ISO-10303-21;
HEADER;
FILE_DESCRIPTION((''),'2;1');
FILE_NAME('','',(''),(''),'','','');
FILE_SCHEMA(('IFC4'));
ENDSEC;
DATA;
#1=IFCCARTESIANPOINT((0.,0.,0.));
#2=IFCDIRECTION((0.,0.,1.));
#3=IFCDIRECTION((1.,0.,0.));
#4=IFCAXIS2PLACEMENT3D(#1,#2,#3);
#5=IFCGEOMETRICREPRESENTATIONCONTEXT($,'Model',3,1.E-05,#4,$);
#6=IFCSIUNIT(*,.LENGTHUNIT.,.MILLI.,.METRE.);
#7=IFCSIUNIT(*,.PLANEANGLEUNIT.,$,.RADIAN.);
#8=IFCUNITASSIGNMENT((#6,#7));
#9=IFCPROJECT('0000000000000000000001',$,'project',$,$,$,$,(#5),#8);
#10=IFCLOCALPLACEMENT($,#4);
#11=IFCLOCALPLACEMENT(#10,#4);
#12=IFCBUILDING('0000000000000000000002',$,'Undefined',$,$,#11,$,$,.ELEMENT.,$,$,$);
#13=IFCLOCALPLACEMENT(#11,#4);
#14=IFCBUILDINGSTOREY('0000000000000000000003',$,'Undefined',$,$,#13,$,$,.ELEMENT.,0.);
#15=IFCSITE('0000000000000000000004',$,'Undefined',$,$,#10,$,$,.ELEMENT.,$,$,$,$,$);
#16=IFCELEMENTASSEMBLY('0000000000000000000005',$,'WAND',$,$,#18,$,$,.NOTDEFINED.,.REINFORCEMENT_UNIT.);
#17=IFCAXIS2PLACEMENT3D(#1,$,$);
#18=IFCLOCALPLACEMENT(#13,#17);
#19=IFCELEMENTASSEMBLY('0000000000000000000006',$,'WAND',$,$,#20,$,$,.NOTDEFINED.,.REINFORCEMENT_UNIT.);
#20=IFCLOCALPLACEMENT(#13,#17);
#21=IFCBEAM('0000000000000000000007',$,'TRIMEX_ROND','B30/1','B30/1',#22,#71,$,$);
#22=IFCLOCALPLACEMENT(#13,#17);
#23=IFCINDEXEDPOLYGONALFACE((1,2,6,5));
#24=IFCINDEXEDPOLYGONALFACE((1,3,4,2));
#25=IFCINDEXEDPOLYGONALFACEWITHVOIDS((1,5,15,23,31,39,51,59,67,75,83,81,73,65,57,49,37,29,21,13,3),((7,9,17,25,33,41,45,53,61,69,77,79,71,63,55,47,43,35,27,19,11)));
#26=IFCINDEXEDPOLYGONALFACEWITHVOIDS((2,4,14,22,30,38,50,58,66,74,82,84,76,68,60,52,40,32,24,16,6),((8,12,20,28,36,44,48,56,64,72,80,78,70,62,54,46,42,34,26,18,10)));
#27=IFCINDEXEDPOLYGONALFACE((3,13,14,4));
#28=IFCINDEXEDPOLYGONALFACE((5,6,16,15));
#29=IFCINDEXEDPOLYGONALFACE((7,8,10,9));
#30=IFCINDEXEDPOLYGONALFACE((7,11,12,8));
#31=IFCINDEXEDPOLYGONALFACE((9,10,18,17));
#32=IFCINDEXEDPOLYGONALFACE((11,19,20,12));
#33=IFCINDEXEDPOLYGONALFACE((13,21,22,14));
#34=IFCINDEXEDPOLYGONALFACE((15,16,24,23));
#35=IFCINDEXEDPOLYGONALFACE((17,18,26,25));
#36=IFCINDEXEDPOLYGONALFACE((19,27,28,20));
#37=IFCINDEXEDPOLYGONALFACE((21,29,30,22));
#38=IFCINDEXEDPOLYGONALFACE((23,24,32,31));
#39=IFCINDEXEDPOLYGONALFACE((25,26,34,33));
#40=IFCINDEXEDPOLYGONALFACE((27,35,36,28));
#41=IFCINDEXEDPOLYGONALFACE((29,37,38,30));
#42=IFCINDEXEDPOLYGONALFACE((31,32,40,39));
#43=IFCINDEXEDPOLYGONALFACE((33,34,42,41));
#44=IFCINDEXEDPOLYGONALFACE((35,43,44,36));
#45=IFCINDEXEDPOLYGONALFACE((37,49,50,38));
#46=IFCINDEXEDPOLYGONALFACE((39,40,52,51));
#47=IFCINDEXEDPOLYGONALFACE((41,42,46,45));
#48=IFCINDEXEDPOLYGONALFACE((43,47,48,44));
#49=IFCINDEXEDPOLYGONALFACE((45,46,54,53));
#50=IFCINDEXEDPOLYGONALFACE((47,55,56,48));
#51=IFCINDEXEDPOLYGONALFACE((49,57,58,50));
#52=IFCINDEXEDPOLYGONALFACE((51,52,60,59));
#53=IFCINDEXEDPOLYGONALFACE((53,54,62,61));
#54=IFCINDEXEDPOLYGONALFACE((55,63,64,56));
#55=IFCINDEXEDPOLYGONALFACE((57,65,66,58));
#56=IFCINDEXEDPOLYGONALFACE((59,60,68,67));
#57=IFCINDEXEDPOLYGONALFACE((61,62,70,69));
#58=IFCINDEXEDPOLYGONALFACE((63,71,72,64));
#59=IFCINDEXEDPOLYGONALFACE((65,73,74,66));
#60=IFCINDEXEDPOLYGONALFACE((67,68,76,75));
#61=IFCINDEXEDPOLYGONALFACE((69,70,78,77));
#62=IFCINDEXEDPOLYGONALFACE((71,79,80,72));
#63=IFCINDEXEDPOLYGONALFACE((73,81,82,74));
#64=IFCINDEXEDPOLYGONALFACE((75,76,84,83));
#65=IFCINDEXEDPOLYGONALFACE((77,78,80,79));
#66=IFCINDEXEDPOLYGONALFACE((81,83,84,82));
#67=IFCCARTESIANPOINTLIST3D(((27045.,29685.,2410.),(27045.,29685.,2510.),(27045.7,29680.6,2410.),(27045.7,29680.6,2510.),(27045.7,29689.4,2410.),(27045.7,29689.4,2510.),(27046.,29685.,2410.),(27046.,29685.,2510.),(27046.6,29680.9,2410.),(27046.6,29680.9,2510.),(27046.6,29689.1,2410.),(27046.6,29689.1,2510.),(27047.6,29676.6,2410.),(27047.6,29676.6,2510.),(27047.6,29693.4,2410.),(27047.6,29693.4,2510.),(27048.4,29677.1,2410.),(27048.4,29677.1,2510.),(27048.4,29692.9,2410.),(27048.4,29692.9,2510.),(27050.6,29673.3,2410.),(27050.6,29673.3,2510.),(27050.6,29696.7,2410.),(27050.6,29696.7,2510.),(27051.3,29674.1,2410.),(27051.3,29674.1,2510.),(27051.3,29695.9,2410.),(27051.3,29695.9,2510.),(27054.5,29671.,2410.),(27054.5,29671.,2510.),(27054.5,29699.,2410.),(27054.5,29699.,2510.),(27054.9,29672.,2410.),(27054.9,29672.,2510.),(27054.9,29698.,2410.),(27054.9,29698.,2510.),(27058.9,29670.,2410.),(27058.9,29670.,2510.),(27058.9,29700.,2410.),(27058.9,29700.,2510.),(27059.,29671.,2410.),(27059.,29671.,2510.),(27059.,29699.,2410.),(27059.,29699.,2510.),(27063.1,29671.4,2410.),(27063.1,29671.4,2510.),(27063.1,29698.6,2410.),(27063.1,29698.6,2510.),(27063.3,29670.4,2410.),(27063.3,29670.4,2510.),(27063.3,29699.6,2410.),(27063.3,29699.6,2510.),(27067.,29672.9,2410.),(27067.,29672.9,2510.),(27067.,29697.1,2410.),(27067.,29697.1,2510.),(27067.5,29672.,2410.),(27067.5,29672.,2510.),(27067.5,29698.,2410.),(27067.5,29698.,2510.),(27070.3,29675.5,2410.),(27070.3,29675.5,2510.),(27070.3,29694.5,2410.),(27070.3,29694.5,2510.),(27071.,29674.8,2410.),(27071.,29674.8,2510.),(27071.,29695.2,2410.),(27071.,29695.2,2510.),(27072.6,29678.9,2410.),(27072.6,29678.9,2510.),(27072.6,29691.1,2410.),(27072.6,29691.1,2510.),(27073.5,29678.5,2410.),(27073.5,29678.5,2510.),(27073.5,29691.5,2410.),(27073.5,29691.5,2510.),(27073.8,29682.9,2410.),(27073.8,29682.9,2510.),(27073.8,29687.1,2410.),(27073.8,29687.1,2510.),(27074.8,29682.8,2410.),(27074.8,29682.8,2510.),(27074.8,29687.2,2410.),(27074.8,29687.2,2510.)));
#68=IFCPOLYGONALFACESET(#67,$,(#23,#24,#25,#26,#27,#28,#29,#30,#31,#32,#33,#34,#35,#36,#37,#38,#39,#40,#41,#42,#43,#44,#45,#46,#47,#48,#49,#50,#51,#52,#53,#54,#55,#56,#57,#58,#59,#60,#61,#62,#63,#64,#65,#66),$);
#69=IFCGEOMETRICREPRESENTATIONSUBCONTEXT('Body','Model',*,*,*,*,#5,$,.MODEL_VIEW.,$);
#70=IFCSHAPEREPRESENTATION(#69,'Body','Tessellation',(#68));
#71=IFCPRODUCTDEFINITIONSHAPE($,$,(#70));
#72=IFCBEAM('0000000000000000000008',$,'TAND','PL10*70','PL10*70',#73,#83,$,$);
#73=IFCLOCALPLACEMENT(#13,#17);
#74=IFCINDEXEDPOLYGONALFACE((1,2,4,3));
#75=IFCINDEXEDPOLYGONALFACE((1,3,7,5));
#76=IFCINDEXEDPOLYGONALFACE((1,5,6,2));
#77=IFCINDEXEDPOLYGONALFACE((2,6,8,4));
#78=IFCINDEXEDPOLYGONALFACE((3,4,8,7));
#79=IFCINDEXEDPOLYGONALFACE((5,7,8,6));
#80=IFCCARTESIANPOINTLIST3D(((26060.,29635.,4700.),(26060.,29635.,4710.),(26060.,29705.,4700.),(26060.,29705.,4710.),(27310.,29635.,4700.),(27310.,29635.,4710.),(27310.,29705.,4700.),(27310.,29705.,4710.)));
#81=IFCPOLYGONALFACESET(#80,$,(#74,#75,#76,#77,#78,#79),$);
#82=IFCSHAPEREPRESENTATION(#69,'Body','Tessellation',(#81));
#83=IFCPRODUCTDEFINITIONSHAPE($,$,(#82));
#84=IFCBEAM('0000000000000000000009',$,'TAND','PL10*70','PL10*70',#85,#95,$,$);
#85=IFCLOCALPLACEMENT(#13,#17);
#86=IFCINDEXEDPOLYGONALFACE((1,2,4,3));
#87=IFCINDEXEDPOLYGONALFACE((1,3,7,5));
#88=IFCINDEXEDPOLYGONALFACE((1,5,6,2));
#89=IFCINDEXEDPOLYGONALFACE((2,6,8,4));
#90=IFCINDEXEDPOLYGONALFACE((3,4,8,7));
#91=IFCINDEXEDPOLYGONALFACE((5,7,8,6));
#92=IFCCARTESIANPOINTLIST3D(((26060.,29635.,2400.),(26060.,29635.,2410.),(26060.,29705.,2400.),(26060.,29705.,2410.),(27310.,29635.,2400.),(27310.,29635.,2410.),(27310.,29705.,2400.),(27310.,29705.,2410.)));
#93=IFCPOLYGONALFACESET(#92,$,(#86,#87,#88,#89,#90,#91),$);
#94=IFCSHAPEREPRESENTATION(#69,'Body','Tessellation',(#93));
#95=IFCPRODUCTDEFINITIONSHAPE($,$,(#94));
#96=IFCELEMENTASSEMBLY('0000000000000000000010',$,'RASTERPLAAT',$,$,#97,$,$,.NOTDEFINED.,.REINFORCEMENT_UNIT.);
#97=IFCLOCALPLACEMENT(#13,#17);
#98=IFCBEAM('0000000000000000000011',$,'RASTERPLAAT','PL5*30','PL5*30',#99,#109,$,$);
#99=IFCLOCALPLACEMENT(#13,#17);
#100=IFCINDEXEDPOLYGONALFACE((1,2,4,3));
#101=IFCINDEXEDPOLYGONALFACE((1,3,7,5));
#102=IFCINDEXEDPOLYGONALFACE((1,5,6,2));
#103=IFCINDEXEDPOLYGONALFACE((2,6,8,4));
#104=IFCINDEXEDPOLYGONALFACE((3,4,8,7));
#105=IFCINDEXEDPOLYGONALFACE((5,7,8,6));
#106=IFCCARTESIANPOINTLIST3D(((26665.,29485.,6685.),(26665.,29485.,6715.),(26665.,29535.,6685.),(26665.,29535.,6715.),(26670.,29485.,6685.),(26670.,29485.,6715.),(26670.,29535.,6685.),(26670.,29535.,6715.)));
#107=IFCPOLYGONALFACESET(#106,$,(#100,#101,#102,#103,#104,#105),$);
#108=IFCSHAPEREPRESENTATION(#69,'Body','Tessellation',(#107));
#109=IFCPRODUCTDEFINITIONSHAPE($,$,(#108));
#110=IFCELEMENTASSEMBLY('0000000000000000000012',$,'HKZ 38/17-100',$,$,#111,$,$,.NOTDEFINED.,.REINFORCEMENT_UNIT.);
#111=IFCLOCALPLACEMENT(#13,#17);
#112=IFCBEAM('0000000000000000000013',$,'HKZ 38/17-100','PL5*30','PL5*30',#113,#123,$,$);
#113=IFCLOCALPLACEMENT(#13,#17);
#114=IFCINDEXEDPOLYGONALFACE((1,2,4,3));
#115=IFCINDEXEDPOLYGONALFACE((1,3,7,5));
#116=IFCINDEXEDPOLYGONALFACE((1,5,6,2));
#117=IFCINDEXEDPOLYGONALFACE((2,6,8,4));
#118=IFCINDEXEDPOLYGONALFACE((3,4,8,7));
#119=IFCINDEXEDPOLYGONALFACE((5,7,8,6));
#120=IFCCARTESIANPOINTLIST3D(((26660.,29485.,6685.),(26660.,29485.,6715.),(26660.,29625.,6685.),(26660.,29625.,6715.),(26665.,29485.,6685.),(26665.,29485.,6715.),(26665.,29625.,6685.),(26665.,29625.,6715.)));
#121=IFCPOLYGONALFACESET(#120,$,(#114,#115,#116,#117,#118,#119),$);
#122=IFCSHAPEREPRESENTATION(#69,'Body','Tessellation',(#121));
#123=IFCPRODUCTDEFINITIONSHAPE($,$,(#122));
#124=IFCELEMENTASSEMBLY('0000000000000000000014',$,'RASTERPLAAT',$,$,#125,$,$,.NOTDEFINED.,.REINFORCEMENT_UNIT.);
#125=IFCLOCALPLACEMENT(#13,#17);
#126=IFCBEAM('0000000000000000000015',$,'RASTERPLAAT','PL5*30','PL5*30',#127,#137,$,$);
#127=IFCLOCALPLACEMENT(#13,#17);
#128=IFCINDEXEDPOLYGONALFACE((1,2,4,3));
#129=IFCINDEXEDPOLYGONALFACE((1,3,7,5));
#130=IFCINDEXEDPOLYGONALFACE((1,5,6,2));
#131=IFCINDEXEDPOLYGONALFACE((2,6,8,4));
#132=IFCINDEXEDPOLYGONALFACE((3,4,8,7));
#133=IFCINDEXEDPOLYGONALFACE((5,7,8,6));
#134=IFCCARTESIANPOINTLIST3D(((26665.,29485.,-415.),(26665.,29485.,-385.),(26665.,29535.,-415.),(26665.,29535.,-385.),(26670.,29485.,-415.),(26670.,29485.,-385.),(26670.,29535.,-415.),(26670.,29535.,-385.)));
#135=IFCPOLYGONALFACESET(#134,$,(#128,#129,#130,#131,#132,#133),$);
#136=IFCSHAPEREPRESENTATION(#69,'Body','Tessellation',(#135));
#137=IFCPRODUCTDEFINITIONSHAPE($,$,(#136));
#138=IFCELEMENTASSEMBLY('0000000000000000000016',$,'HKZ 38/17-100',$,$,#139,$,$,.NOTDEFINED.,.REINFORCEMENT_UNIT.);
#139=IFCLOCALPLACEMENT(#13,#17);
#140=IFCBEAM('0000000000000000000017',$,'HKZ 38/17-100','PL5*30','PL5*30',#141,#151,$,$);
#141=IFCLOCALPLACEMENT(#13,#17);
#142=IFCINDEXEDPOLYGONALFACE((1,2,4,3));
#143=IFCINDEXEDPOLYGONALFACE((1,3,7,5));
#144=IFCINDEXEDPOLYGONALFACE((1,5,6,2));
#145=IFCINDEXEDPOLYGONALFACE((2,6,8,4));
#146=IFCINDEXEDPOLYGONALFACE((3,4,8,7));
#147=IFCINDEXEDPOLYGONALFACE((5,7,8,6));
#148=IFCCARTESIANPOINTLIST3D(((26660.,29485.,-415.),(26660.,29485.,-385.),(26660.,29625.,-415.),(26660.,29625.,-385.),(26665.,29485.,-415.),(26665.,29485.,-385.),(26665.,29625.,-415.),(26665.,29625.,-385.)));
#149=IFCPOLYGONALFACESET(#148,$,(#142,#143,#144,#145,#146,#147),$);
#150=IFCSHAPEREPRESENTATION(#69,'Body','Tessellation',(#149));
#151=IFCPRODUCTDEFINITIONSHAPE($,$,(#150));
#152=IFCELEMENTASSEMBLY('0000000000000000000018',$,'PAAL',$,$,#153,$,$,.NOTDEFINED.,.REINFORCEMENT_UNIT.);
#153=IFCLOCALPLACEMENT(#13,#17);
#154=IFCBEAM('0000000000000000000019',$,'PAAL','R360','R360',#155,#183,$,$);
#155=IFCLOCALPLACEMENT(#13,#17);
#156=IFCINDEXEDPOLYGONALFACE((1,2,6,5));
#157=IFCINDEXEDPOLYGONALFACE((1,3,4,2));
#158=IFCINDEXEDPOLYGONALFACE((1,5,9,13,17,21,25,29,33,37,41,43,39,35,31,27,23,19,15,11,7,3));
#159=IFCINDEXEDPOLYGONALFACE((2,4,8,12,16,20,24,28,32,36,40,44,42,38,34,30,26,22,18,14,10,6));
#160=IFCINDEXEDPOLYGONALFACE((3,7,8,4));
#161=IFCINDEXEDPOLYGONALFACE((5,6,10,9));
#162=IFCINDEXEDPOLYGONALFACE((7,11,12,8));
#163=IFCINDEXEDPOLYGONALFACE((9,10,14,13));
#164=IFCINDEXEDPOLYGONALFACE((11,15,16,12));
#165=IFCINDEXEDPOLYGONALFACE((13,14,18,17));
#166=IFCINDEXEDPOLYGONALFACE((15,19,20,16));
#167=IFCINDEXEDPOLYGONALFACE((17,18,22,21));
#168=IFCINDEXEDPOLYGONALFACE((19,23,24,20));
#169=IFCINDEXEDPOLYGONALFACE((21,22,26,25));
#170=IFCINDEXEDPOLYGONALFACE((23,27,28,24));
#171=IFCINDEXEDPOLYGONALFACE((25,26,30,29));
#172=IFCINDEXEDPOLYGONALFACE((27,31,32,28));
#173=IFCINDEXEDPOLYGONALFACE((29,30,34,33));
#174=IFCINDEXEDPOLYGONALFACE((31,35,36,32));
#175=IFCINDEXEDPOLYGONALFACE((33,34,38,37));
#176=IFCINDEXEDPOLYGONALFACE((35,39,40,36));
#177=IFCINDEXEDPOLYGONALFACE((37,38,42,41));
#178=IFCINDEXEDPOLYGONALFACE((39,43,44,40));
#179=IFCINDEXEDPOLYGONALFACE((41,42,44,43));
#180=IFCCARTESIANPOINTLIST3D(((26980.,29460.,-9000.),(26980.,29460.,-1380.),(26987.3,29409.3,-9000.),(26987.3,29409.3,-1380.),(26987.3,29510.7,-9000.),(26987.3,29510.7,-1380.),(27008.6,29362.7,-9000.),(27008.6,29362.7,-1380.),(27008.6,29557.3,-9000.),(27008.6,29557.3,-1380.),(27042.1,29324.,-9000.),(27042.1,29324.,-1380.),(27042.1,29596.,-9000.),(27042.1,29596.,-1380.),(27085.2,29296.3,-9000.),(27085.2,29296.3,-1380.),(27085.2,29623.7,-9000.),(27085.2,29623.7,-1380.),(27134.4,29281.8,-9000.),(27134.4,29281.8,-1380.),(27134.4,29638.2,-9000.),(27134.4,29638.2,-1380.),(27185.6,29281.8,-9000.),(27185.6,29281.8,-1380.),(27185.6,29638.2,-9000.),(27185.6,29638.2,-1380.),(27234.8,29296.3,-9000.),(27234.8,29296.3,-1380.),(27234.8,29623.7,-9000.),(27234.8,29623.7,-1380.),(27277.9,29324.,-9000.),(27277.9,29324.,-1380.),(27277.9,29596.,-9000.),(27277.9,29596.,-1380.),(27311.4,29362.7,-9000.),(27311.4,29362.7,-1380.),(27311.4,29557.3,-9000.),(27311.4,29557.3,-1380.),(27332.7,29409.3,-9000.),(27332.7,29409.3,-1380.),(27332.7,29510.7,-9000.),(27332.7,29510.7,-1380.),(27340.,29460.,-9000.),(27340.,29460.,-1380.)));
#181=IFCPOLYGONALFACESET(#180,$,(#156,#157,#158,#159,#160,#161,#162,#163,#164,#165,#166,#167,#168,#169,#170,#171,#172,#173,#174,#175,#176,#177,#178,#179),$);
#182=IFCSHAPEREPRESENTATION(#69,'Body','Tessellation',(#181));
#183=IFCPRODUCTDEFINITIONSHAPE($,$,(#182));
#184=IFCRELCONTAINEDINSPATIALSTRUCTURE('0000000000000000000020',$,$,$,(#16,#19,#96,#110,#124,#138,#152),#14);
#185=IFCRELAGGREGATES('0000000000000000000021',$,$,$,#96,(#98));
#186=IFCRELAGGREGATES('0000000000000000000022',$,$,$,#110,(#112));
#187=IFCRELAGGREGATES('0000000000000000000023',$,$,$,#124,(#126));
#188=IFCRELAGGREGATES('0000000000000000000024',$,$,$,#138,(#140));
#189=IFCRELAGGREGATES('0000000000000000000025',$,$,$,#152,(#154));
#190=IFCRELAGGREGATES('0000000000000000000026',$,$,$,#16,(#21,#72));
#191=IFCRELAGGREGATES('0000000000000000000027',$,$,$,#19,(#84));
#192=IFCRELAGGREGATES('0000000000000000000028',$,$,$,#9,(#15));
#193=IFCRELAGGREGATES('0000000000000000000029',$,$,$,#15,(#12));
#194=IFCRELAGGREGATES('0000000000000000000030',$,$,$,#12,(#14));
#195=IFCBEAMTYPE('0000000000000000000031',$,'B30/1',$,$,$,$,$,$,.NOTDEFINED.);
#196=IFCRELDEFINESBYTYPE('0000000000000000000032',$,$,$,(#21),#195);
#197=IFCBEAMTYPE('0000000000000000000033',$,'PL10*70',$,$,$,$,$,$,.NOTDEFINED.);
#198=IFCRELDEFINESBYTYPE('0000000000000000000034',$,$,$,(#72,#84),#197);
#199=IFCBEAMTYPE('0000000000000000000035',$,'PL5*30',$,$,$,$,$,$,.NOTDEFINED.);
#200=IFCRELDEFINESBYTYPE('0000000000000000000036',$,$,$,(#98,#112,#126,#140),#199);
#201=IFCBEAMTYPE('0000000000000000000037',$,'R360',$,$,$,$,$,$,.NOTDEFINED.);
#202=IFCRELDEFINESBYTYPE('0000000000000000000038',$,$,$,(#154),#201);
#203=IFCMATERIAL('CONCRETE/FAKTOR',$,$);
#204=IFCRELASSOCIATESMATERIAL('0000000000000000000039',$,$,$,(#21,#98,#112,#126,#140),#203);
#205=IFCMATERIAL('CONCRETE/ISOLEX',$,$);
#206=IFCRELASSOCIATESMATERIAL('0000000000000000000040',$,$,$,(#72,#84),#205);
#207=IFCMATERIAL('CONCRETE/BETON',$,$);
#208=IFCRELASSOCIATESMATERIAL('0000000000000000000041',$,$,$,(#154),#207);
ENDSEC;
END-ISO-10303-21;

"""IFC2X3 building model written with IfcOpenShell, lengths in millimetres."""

from ifc_helpers import new_model, si_unit, frame, frame_2d, origin_with_axes, place, context, subcontext, project, spatial, rectangle, circle, hollow_circle, extrude, material, type_object, element, aggregate, save


model = new_model("IFC2X3")

# Units and contexts
model_context = context("Model", 3, precision=1e-05, world=origin_with_axes())
body_context = subcontext(model_context, "Body", "Model", "MODEL_VIEW")
ifc_project = project(units=[si_unit("LENGTHUNIT", "METRE", prefix="MILLI"), si_unit("PLANEANGLEUNIT", "RADIAN")], contexts=[model_context])

# Site, building, storey
site_placement = place(None, origin_with_axes())
site = spatial("IfcSite", under=ifc_project, at=site_placement, Name="Undefined", CompositionType="ELEMENT")
building_placement = place(site_placement, origin_with_axes())
building = spatial("IfcBuilding", under=site, at=building_placement, Name="Undefined", CompositionType="ELEMENT")
storey_placement = place(building_placement, origin_with_axes())
storey = spatial("IfcBuildingStorey", under=building, at=storey_placement, Name="Undefined", CompositionType="ELEMENT", Elevation=0.0)

# Element assemblies
assembly_1_placement = place(storey_placement, origin_with_axes())
assembly_1 = element("IfcElementAssembly", 1, at=assembly_1_placement, inside=storey, Name="WAND", AssemblyPlace="NOTDEFINED", PredefinedType="REINFORCEMENT_UNIT")
ifc_material_1 = material(Name="CONCRETE/BETON")
assembly_2_placement = place(storey_placement, origin_with_axes())
assembly_2 = element("IfcElementAssembly", 2, at=assembly_2_placement, inside=storey, Name="WAND", AssemblyPlace="NOTDEFINED", PredefinedType="REINFORCEMENT_UNIT")
ifc_material_2 = material(Name="CONCRETE/FAKTOR")

# Shared definitions
beam_type_1 = type_object("IfcBeamType", Name="B30/1", PredefinedType="NOTDEFINED")

# Beams
beam_1_placement = place(assembly_1_placement, frame((27060.0, 29685.0, 2410.0), z_axis=(0.0, 1.0, 0.0), x_axis=(0.0, 0.0, 1.0)))
beam_1 = element("IfcBeam", 3, at=beam_1_placement, type_object=beam_type_1, material=ifc_material_2, Name="TRIMEX_ROND", Description="B30/1", ObjectType="B30/1", context=body_context, shape_type="SweptSolid", body=[
    extrude(hollow_circle(Radius=15.0, WallThickness=1.0, at=frame_2d((0.0, 0.0), x_axis=(1.0, 0.0))), frame((100.0, 0.0, 0.0), z_axis=(-1.0, 0.0, 0.0), x_axis=(0.0, -1.0, 0.0)), (0.0, 0.0, 1.0), 100.0),
])
ifc_material_3 = material(Name="CONCRETE/ISOLEX")
beam_type_2 = type_object("IfcBeamType", Name="PL10*70", PredefinedType="NOTDEFINED")
beam_2_placement = place(assembly_1_placement, frame((27310.0, 29670.0, 4705.0), z_axis=(0.0, 1.0, 0.0), x_axis=(-1.0, 0.0, 0.0)))
beam_2 = element("IfcBeam", 4, at=beam_2_placement, type_object=beam_type_2, material=ifc_material_3, Name="TAND", Description="PL10*70", ObjectType="PL10*70", context=body_context, shape_type="SweptSolid", body=[
    extrude(rectangle(XDim=10.0, YDim=70.0, at=frame_2d((0.0, 0.0), x_axis=(1.0, 0.0))), frame((1250.0, 0.0, 0.0), z_axis=(-1.0, 0.0, 0.0), x_axis=(0.0, -1.0, 0.0)), (0.0, 0.0, 1.0), 1250.0),
])
beam_3_placement = place(assembly_2_placement, frame((27310.0, 29670.0, 2405.0), z_axis=(0.0, 1.0, 0.0), x_axis=(-1.0, 0.0, 0.0)))
beam_3 = element("IfcBeam", 5, at=beam_3_placement, type_object=beam_type_2, material=ifc_material_3, Name="TAND", Description="PL10*70", ObjectType="PL10*70", context=body_context, shape_type="SweptSolid", body=[
    extrude(rectangle(XDim=10.0, YDim=70.0, at=frame_2d((0.0, 0.0), x_axis=(1.0, 0.0))), frame((1250.0, 0.0, 0.0), z_axis=(-1.0, 0.0, 0.0), x_axis=(0.0, -1.0, 0.0)), (0.0, 0.0, 1.0), 1250.0),
])

# Element assemblies, beams
assembly_3_placement = place(storey_placement, origin_with_axes())
assembly_3 = element("IfcElementAssembly", 6, at=assembly_3_placement, inside=storey, Name="RASTERPLAAT", AssemblyPlace="NOTDEFINED", PredefinedType="REINFORCEMENT_UNIT")
beam_type_3 = type_object("IfcBeamType", Name="PL5*30", PredefinedType="NOTDEFINED")
beam_4_placement = place(assembly_3_placement, frame((26667.5, 29485.0, 6700.0), z_axis=(0.0, 0.0, -1.0), x_axis=(0.0, 1.0, 0.0)))
beam_4 = element("IfcBeam", 7, at=beam_4_placement, type_object=beam_type_3, material=ifc_material_2, Name="RASTERPLAAT", Description="PL5*30", ObjectType="PL5*30", context=body_context, shape_type="SweptSolid", body=[
    extrude(rectangle(XDim=5.0, YDim=30.0, at=frame_2d((0.0, 0.0), x_axis=(1.0, 0.0))), frame((50.0, 0.0, 0.0), z_axis=(-1.0, 0.0, 0.0), x_axis=(0.0, -1.0, 0.0)), (0.0, 0.0, 1.0), 50.0),
])
aggregate(assembly_3, [beam_4])
assembly_4_placement = place(storey_placement, origin_with_axes())
assembly_4 = element("IfcElementAssembly", 8, at=assembly_4_placement, inside=storey, Name="HKZ 38/17-100", AssemblyPlace="NOTDEFINED", PredefinedType="REINFORCEMENT_UNIT")
beam_5_placement = place(assembly_4_placement, frame((26662.5, 29625.0, 6700.0), z_axis=(0.0, 0.0, -1.0), x_axis=(0.0, -1.0, 0.0)))
beam_5 = element("IfcBeam", 9, at=beam_5_placement, type_object=beam_type_3, material=ifc_material_2, Name="HKZ 38/17-100", Description="PL5*30", ObjectType="PL5*30", context=body_context, shape_type="SweptSolid", body=[
    extrude(rectangle(XDim=5.0, YDim=30.0, at=frame_2d((0.0, 0.0), x_axis=(1.0, 0.0))), frame((140.0, 0.0, 0.0), z_axis=(-1.0, 0.0, 0.0), x_axis=(0.0, -1.0, 0.0)), (0.0, 0.0, 1.0), 140.0),
])
aggregate(assembly_4, [beam_5])
assembly_5_placement = place(storey_placement, origin_with_axes())
assembly_5 = element("IfcElementAssembly", 10, at=assembly_5_placement, inside=storey, Name="RASTERPLAAT", AssemblyPlace="NOTDEFINED", PredefinedType="REINFORCEMENT_UNIT")
beam_6_placement = place(assembly_5_placement, frame((26667.5, 29485.0, -400.0), z_axis=(0.0, 0.0, -1.0), x_axis=(0.0, 1.0, 0.0)))
beam_6 = element("IfcBeam", 11, at=beam_6_placement, type_object=beam_type_3, material=ifc_material_2, Name="RASTERPLAAT", Description="PL5*30", ObjectType="PL5*30", context=body_context, shape_type="SweptSolid", body=[
    extrude(rectangle(XDim=5.0, YDim=30.0, at=frame_2d((0.0, 0.0), x_axis=(1.0, 0.0))), frame((50.0, 0.0, 0.0), z_axis=(-1.0, 0.0, 0.0), x_axis=(0.0, -1.0, 0.0)), (0.0, 0.0, 1.0), 50.0),
])
aggregate(assembly_5, [beam_6])
assembly_6_placement = place(storey_placement, origin_with_axes())
assembly_6 = element("IfcElementAssembly", 12, at=assembly_6_placement, inside=storey, Name="HKZ 38/17-100", AssemblyPlace="NOTDEFINED", PredefinedType="REINFORCEMENT_UNIT")
beam_7_placement = place(assembly_6_placement, frame((26662.5, 29625.0, -400.0), z_axis=(0.0, 0.0, -1.0), x_axis=(0.0, -1.0, 0.0)))
beam_7 = element("IfcBeam", 13, at=beam_7_placement, type_object=beam_type_3, material=ifc_material_2, Name="HKZ 38/17-100", Description="PL5*30", ObjectType="PL5*30", context=body_context, shape_type="SweptSolid", body=[
    extrude(rectangle(XDim=5.0, YDim=30.0, at=frame_2d((0.0, 0.0), x_axis=(1.0, 0.0))), frame((140.0, 0.0, 0.0), z_axis=(-1.0, 0.0, 0.0), x_axis=(0.0, -1.0, 0.0)), (0.0, 0.0, 1.0), 140.0),
])
aggregate(assembly_6, [beam_7])
assembly_7_placement = place(storey_placement, origin_with_axes())
assembly_7 = element("IfcElementAssembly", 14, at=assembly_7_placement, inside=storey, Name="PAAL", AssemblyPlace="NOTDEFINED", PredefinedType="REINFORCEMENT_UNIT")
beam_type_4 = type_object("IfcBeamType", Name="R360", PredefinedType="NOTDEFINED")
beam_8_placement = place(assembly_7_placement, frame((27160.0, 29460.0, -1380.0), z_axis=(0.0, -1.0, 0.0), x_axis=(0.0, 0.0, -1.0)))
beam_8 = element("IfcBeam", 15, at=beam_8_placement, type_object=beam_type_4, material=ifc_material_1, Name="PAAL", Description="R360", ObjectType="R360", context=body_context, shape_type="SweptSolid", body=[
    extrude(circle(Radius=180.0, at=frame_2d((0.0, 0.0), x_axis=(1.0, 0.0))), frame((7620.0, 0.0, 0.0), z_axis=(-1.0, 0.0, 0.0), x_axis=(0.0, -1.0, 0.0)), (0.0, 0.0, 1.0), 7620.0),
])
aggregate(assembly_7, [beam_8])

aggregate(assembly_1, [beam_1, beam_2])
aggregate(assembly_2, [beam_3])

save(model, "model.ifc")
